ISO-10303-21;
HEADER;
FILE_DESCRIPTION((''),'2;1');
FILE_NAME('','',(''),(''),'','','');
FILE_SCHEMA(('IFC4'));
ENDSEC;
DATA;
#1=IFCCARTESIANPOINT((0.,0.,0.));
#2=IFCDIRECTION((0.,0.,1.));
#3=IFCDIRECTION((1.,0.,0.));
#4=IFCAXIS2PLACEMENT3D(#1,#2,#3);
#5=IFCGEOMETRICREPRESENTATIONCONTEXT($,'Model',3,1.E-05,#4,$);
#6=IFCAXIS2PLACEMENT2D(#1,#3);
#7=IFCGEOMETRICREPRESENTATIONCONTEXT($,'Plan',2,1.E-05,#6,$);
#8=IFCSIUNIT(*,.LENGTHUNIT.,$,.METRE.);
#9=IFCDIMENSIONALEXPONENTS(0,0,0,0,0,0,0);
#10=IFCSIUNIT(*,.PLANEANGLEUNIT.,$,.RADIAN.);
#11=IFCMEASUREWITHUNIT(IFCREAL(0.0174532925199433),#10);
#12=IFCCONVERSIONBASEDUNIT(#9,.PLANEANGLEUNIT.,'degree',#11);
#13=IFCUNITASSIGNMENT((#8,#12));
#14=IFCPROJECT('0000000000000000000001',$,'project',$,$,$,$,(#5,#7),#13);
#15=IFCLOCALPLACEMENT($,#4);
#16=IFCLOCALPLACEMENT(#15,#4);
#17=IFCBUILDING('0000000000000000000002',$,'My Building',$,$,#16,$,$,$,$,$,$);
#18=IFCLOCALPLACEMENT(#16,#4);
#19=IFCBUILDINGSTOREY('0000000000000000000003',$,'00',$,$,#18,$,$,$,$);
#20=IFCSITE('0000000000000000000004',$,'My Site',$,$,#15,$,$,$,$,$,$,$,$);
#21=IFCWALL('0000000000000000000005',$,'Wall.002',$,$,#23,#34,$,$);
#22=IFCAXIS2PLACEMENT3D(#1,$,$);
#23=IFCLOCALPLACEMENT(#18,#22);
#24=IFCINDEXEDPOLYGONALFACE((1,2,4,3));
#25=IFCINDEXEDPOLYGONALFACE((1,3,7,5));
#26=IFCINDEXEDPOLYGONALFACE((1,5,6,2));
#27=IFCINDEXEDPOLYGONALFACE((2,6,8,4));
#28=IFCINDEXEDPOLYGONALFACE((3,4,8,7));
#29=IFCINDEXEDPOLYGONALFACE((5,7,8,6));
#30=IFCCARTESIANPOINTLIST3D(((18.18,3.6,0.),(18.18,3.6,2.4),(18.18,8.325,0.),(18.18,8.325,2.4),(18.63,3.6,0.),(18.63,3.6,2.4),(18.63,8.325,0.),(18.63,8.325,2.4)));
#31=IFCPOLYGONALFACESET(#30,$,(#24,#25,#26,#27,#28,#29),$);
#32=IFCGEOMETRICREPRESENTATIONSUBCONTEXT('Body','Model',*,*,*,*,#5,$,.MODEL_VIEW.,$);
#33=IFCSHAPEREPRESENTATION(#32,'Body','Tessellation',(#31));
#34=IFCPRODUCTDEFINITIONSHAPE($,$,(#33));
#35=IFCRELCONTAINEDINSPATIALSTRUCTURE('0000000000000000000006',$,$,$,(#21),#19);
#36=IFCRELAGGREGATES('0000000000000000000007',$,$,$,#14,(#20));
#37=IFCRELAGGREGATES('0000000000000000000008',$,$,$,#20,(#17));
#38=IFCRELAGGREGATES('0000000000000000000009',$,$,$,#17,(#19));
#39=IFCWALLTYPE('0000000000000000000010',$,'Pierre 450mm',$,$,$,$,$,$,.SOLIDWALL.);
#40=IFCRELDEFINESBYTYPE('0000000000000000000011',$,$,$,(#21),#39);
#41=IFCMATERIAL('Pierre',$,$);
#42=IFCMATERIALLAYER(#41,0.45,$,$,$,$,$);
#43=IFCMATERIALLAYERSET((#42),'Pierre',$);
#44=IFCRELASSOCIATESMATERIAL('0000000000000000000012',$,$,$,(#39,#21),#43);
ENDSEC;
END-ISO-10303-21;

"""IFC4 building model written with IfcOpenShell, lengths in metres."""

from ifc_helpers import new_model, entity, si_unit, converted_unit, frame, frame_2d, origin_with_axes, place, context, subcontext, project, spatial, polyline, outline, extrude, material, layer, layer_set, layer_usage, type_object, element, save


model = new_model("IFC4")

# Units and contexts
model_context = context("Model", 3, precision=1e-05, world=origin_with_axes())
plan_context = context("Plan", 2, precision=1e-05, world=frame_2d((0.0, 0.0, 0.0), x_axis=(1.0, 0.0, 0.0)))
body_context = subcontext(model_context, "Body", "Model", "MODEL_VIEW")
ifc_project = project(units=[si_unit("LENGTHUNIT", "METRE"), converted_unit("PLANEANGLEUNIT", "degree", entity("IfcReal", 0.0174532925199433), si_unit("PLANEANGLEUNIT", "RADIAN"), dimensions=[0, 0, 0, 0, 0, 0, 0])], contexts=[model_context, plan_context])

# Site, building, storey
site_placement = place(None, origin_with_axes())
site = spatial("IfcSite", under=ifc_project, at=site_placement, Name="My Site")
building_placement = place(site_placement, origin_with_axes())
building = spatial("IfcBuilding", under=site, at=building_placement, Name="My Building")
storey_placement = place(building_placement, origin_with_axes())
storey = spatial("IfcBuildingStorey", under=building, at=storey_placement, Name="00")

# Wall
ifc_material = material(Name="Pierre")
ifc_layer = layer(ifc_material, 0.45)
ifc_layer_set = layer_set([ifc_layer], Name="Pierre")
wall_type = type_object("IfcWallType", Name="Pierre 450mm", PredefinedType="SOLIDWALL", material=ifc_layer_set)
ifc_layer_usage_1 = layer_usage(ifc_layer_set, "AXIS2", "POSITIVE", 0.0)
wall_1_placement = place(storey_placement, frame((18.18, 8.325, 0.0), z_axis=(0.0, 0.0, 1.0), x_axis=(0.0, -1.0, 0.0)))
element("IfcWall", 1, at=wall_1_placement, inside=storey, type_object=wall_type, material=ifc_layer_usage_1, Name="Wall.002", context=body_context, shape_type="SweptSolid", body=[
    extrude(outline(polyline([(-0.225, -2.3625), (0.225, -2.3625), (0.225, 2.3625), (-0.225, 2.3625), (-0.225, -2.3625)])), frame((2.3625, 0.225, 0.0), z_axis=(0.0, 0.0, -1.0), x_axis=(0.0, -1.0, 0.0)), (0.0, 0.0, -1.0), 2.4),
])

save(model, "model.ifc")
